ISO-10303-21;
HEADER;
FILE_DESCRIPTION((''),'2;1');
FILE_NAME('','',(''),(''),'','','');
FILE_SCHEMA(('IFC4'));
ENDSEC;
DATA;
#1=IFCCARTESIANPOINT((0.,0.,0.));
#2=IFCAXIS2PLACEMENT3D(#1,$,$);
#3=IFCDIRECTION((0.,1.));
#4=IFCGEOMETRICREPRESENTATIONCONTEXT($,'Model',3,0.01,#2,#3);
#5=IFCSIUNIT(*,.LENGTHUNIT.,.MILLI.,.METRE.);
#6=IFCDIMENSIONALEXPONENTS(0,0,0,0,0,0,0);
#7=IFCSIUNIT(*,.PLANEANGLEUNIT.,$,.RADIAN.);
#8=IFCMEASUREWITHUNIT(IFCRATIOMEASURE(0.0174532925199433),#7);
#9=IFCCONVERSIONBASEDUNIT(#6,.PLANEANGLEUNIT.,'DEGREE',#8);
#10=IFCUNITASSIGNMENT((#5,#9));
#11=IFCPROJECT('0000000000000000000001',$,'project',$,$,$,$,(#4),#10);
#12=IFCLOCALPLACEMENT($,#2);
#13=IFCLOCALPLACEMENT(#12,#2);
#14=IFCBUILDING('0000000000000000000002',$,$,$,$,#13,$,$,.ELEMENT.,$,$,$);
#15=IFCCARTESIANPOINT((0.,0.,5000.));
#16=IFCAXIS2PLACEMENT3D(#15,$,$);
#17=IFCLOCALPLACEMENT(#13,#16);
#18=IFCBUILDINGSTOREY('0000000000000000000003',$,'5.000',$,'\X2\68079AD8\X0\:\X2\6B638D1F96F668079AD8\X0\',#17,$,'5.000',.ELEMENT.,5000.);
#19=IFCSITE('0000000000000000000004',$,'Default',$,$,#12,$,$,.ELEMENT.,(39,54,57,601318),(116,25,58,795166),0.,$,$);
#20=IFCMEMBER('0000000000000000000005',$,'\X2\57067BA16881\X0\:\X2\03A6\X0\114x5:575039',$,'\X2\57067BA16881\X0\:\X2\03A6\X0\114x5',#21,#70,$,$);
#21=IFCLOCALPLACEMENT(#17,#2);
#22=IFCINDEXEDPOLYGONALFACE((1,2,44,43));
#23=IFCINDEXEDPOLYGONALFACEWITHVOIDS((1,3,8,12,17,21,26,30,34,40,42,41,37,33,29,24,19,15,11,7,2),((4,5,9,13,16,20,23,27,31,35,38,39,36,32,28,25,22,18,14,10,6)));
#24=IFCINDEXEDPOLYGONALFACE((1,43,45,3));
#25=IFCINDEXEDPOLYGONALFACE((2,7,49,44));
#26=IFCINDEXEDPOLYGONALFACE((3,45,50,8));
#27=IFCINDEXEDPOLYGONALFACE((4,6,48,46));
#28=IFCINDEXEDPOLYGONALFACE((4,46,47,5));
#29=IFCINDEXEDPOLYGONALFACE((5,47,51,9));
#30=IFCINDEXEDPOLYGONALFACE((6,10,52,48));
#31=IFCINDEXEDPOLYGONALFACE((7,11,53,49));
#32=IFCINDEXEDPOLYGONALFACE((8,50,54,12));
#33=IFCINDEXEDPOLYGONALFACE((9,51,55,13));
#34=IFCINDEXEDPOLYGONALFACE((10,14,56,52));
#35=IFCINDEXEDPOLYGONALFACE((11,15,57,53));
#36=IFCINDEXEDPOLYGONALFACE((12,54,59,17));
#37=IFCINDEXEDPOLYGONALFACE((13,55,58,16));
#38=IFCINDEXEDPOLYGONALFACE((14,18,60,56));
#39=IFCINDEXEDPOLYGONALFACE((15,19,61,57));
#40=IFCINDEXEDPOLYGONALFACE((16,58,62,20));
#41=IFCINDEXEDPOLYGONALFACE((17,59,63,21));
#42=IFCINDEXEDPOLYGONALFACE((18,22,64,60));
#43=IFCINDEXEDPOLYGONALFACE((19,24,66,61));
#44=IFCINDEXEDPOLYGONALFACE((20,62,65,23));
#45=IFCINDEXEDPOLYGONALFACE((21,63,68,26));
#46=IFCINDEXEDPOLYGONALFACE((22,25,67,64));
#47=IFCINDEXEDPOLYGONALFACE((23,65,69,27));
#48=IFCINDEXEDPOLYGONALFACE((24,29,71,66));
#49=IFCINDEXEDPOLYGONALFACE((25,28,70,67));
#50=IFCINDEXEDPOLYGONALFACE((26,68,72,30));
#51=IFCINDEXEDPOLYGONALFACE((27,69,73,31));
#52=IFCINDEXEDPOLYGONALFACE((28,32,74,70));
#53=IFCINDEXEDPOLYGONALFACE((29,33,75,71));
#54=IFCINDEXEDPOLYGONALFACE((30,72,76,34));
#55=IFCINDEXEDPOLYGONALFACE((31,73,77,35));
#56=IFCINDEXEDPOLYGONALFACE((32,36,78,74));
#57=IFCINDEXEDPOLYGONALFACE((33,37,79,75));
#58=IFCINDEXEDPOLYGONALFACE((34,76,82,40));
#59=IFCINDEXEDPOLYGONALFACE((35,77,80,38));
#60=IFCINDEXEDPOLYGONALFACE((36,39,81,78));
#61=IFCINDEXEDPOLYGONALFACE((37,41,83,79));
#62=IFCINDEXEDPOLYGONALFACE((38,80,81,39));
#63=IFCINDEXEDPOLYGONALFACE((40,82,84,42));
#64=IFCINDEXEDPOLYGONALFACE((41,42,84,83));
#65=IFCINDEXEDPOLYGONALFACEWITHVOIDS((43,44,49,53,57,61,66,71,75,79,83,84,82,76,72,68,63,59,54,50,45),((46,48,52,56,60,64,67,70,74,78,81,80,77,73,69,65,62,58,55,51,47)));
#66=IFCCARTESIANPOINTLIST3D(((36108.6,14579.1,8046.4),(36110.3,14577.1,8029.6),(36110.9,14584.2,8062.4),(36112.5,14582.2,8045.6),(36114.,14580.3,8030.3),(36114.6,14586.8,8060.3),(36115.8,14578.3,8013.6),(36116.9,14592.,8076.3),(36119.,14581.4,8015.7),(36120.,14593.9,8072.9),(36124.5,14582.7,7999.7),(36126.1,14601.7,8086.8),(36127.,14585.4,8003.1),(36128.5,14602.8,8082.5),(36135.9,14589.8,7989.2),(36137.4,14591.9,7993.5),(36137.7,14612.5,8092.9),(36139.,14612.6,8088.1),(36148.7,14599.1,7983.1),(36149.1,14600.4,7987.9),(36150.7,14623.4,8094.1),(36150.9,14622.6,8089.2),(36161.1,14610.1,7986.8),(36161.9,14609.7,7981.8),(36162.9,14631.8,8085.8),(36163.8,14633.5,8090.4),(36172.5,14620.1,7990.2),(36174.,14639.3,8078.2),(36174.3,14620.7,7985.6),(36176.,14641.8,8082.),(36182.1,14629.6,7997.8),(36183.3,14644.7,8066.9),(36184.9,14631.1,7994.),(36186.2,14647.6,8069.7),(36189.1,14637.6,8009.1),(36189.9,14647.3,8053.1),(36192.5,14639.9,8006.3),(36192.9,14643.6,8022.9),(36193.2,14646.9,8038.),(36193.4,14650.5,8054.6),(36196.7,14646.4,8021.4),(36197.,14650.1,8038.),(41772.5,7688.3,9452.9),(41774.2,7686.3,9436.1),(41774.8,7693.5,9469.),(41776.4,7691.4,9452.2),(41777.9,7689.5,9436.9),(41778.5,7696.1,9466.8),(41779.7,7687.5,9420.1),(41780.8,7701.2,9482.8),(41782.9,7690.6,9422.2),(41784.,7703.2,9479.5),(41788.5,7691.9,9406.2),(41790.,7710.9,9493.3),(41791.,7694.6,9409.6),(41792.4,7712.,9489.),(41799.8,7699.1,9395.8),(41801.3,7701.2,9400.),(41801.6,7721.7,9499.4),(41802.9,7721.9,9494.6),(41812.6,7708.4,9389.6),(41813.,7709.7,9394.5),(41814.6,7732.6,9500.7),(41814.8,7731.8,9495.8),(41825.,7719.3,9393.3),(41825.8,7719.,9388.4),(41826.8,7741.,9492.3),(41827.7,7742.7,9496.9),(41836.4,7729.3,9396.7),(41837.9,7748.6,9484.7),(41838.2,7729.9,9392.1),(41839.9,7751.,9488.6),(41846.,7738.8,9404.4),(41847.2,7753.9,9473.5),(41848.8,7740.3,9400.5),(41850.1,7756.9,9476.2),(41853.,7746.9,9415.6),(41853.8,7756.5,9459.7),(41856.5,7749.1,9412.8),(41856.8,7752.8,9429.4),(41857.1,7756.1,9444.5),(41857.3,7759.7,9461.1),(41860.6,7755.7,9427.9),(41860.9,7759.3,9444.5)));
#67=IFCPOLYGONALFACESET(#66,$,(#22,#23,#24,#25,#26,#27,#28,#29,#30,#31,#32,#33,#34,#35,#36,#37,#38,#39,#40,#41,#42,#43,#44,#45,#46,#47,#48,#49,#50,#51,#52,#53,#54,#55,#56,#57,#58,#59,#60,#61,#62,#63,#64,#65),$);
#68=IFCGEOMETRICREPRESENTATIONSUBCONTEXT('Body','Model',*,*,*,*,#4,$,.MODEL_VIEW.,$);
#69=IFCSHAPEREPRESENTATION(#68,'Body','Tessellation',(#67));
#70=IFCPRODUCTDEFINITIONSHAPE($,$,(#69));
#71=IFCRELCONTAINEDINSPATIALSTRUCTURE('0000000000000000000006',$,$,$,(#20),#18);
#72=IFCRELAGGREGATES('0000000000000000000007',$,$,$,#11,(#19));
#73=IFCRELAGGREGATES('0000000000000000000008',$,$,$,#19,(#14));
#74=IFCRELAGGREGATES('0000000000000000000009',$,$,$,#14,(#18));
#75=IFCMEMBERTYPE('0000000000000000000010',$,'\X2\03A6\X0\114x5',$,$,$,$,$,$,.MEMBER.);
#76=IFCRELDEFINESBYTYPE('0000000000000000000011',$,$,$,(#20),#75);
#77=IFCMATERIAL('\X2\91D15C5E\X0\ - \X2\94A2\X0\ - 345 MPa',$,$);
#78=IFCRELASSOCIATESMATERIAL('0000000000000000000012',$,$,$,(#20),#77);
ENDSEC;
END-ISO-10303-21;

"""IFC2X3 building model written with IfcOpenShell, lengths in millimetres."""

from ifc_helpers import new_model, entity, si_unit, converted_unit, direction, frame, frame_2d, origin, place, context, subcontext, project, spatial, hollow_circle, extrude, source, transform, mapped, material, type_object, type_shapes, element, save


model = new_model("IFC2X3")

# Units and contexts
model_context = context("Model", 3, precision=0.01, world=origin(), true_north=direction((0.0, 1.0)))
body_context = subcontext(model_context, "Body", "Model", "MODEL_VIEW")
ifc_project = project(units=[si_unit("LENGTHUNIT", "METRE", prefix="MILLI"), converted_unit("PLANEANGLEUNIT", "DEGREE", entity("IfcRatioMeasure", 0.0174532925199433), si_unit("PLANEANGLEUNIT", "RADIAN"), dimensions=[0, 0, 0, 0, 0, 0, 0])], contexts=[model_context])

# Site, building, storey
site_placement = place(None, origin())
site = spatial("IfcSite", under=ifc_project, at=site_placement, Name="Default", CompositionType="ELEMENT", RefLatitude=(39, 54, 57, 601318), RefLongitude=(116, 25, 58, 795166), RefElevation=0.0)
building_placement = place(site_placement, origin())
building = spatial("IfcBuilding", under=site, at=building_placement, CompositionType="ELEMENT")
storey_placement = place(building_placement, frame((0.0, 0.0, 5000.0)))
storey = spatial("IfcBuildingStorey", under=building, at=storey_placement, Name="5.000", ObjectType="标高:正负零标高", LongName="5.000", CompositionType="ELEMENT", Elevation=5000.0)

# Member
ifc_material_1 = material(Name="金属 - 钢 - 345 MPa")
member_type_1 = type_object("IfcMemberType", Name="Φ114x5", PredefinedType="MEMBER")
shared_shape_1 = source(origin(), body_context, "Body", "SweptSolid", [
    extrude(hollow_circle(Radius=57.0, WallThickness=5.0, at=frame_2d((0.0, 0.0), x_axis=(1.0, 0.0))), frame((-4539.0, 0.0, 0.0), z_axis=(1.0, 0.0, 0.0), x_axis=(0.0, 1.0, 0.0)), (0.0, 0.0, 1.0), 9030.0),
])
type_shapes(member_type_1, [shared_shape_1])
for number, where, z_axis, x_axis, name in (
    (1, (39000.0, 11150.2, 8745.0), (-0.098907, 0.120331, 0.987794), (0.627233, -0.763097, 0.155763), "圆管梁:Φ114x5:575039"),
):
    element("IfcMember", number, at=place(storey_placement, frame(where, z_axis=z_axis, x_axis=x_axis)), inside=storey, type_object=member_type_1, material=ifc_material_1, Name=name, ObjectType="圆管梁:Φ114x5", context=body_context, shape_type="MappedRepresentation", body=[
        mapped(shared_shape_1, transform((0.0, 0.0, 0.0), scale=1.0)),
    ])

save(model, "model.ifc")
